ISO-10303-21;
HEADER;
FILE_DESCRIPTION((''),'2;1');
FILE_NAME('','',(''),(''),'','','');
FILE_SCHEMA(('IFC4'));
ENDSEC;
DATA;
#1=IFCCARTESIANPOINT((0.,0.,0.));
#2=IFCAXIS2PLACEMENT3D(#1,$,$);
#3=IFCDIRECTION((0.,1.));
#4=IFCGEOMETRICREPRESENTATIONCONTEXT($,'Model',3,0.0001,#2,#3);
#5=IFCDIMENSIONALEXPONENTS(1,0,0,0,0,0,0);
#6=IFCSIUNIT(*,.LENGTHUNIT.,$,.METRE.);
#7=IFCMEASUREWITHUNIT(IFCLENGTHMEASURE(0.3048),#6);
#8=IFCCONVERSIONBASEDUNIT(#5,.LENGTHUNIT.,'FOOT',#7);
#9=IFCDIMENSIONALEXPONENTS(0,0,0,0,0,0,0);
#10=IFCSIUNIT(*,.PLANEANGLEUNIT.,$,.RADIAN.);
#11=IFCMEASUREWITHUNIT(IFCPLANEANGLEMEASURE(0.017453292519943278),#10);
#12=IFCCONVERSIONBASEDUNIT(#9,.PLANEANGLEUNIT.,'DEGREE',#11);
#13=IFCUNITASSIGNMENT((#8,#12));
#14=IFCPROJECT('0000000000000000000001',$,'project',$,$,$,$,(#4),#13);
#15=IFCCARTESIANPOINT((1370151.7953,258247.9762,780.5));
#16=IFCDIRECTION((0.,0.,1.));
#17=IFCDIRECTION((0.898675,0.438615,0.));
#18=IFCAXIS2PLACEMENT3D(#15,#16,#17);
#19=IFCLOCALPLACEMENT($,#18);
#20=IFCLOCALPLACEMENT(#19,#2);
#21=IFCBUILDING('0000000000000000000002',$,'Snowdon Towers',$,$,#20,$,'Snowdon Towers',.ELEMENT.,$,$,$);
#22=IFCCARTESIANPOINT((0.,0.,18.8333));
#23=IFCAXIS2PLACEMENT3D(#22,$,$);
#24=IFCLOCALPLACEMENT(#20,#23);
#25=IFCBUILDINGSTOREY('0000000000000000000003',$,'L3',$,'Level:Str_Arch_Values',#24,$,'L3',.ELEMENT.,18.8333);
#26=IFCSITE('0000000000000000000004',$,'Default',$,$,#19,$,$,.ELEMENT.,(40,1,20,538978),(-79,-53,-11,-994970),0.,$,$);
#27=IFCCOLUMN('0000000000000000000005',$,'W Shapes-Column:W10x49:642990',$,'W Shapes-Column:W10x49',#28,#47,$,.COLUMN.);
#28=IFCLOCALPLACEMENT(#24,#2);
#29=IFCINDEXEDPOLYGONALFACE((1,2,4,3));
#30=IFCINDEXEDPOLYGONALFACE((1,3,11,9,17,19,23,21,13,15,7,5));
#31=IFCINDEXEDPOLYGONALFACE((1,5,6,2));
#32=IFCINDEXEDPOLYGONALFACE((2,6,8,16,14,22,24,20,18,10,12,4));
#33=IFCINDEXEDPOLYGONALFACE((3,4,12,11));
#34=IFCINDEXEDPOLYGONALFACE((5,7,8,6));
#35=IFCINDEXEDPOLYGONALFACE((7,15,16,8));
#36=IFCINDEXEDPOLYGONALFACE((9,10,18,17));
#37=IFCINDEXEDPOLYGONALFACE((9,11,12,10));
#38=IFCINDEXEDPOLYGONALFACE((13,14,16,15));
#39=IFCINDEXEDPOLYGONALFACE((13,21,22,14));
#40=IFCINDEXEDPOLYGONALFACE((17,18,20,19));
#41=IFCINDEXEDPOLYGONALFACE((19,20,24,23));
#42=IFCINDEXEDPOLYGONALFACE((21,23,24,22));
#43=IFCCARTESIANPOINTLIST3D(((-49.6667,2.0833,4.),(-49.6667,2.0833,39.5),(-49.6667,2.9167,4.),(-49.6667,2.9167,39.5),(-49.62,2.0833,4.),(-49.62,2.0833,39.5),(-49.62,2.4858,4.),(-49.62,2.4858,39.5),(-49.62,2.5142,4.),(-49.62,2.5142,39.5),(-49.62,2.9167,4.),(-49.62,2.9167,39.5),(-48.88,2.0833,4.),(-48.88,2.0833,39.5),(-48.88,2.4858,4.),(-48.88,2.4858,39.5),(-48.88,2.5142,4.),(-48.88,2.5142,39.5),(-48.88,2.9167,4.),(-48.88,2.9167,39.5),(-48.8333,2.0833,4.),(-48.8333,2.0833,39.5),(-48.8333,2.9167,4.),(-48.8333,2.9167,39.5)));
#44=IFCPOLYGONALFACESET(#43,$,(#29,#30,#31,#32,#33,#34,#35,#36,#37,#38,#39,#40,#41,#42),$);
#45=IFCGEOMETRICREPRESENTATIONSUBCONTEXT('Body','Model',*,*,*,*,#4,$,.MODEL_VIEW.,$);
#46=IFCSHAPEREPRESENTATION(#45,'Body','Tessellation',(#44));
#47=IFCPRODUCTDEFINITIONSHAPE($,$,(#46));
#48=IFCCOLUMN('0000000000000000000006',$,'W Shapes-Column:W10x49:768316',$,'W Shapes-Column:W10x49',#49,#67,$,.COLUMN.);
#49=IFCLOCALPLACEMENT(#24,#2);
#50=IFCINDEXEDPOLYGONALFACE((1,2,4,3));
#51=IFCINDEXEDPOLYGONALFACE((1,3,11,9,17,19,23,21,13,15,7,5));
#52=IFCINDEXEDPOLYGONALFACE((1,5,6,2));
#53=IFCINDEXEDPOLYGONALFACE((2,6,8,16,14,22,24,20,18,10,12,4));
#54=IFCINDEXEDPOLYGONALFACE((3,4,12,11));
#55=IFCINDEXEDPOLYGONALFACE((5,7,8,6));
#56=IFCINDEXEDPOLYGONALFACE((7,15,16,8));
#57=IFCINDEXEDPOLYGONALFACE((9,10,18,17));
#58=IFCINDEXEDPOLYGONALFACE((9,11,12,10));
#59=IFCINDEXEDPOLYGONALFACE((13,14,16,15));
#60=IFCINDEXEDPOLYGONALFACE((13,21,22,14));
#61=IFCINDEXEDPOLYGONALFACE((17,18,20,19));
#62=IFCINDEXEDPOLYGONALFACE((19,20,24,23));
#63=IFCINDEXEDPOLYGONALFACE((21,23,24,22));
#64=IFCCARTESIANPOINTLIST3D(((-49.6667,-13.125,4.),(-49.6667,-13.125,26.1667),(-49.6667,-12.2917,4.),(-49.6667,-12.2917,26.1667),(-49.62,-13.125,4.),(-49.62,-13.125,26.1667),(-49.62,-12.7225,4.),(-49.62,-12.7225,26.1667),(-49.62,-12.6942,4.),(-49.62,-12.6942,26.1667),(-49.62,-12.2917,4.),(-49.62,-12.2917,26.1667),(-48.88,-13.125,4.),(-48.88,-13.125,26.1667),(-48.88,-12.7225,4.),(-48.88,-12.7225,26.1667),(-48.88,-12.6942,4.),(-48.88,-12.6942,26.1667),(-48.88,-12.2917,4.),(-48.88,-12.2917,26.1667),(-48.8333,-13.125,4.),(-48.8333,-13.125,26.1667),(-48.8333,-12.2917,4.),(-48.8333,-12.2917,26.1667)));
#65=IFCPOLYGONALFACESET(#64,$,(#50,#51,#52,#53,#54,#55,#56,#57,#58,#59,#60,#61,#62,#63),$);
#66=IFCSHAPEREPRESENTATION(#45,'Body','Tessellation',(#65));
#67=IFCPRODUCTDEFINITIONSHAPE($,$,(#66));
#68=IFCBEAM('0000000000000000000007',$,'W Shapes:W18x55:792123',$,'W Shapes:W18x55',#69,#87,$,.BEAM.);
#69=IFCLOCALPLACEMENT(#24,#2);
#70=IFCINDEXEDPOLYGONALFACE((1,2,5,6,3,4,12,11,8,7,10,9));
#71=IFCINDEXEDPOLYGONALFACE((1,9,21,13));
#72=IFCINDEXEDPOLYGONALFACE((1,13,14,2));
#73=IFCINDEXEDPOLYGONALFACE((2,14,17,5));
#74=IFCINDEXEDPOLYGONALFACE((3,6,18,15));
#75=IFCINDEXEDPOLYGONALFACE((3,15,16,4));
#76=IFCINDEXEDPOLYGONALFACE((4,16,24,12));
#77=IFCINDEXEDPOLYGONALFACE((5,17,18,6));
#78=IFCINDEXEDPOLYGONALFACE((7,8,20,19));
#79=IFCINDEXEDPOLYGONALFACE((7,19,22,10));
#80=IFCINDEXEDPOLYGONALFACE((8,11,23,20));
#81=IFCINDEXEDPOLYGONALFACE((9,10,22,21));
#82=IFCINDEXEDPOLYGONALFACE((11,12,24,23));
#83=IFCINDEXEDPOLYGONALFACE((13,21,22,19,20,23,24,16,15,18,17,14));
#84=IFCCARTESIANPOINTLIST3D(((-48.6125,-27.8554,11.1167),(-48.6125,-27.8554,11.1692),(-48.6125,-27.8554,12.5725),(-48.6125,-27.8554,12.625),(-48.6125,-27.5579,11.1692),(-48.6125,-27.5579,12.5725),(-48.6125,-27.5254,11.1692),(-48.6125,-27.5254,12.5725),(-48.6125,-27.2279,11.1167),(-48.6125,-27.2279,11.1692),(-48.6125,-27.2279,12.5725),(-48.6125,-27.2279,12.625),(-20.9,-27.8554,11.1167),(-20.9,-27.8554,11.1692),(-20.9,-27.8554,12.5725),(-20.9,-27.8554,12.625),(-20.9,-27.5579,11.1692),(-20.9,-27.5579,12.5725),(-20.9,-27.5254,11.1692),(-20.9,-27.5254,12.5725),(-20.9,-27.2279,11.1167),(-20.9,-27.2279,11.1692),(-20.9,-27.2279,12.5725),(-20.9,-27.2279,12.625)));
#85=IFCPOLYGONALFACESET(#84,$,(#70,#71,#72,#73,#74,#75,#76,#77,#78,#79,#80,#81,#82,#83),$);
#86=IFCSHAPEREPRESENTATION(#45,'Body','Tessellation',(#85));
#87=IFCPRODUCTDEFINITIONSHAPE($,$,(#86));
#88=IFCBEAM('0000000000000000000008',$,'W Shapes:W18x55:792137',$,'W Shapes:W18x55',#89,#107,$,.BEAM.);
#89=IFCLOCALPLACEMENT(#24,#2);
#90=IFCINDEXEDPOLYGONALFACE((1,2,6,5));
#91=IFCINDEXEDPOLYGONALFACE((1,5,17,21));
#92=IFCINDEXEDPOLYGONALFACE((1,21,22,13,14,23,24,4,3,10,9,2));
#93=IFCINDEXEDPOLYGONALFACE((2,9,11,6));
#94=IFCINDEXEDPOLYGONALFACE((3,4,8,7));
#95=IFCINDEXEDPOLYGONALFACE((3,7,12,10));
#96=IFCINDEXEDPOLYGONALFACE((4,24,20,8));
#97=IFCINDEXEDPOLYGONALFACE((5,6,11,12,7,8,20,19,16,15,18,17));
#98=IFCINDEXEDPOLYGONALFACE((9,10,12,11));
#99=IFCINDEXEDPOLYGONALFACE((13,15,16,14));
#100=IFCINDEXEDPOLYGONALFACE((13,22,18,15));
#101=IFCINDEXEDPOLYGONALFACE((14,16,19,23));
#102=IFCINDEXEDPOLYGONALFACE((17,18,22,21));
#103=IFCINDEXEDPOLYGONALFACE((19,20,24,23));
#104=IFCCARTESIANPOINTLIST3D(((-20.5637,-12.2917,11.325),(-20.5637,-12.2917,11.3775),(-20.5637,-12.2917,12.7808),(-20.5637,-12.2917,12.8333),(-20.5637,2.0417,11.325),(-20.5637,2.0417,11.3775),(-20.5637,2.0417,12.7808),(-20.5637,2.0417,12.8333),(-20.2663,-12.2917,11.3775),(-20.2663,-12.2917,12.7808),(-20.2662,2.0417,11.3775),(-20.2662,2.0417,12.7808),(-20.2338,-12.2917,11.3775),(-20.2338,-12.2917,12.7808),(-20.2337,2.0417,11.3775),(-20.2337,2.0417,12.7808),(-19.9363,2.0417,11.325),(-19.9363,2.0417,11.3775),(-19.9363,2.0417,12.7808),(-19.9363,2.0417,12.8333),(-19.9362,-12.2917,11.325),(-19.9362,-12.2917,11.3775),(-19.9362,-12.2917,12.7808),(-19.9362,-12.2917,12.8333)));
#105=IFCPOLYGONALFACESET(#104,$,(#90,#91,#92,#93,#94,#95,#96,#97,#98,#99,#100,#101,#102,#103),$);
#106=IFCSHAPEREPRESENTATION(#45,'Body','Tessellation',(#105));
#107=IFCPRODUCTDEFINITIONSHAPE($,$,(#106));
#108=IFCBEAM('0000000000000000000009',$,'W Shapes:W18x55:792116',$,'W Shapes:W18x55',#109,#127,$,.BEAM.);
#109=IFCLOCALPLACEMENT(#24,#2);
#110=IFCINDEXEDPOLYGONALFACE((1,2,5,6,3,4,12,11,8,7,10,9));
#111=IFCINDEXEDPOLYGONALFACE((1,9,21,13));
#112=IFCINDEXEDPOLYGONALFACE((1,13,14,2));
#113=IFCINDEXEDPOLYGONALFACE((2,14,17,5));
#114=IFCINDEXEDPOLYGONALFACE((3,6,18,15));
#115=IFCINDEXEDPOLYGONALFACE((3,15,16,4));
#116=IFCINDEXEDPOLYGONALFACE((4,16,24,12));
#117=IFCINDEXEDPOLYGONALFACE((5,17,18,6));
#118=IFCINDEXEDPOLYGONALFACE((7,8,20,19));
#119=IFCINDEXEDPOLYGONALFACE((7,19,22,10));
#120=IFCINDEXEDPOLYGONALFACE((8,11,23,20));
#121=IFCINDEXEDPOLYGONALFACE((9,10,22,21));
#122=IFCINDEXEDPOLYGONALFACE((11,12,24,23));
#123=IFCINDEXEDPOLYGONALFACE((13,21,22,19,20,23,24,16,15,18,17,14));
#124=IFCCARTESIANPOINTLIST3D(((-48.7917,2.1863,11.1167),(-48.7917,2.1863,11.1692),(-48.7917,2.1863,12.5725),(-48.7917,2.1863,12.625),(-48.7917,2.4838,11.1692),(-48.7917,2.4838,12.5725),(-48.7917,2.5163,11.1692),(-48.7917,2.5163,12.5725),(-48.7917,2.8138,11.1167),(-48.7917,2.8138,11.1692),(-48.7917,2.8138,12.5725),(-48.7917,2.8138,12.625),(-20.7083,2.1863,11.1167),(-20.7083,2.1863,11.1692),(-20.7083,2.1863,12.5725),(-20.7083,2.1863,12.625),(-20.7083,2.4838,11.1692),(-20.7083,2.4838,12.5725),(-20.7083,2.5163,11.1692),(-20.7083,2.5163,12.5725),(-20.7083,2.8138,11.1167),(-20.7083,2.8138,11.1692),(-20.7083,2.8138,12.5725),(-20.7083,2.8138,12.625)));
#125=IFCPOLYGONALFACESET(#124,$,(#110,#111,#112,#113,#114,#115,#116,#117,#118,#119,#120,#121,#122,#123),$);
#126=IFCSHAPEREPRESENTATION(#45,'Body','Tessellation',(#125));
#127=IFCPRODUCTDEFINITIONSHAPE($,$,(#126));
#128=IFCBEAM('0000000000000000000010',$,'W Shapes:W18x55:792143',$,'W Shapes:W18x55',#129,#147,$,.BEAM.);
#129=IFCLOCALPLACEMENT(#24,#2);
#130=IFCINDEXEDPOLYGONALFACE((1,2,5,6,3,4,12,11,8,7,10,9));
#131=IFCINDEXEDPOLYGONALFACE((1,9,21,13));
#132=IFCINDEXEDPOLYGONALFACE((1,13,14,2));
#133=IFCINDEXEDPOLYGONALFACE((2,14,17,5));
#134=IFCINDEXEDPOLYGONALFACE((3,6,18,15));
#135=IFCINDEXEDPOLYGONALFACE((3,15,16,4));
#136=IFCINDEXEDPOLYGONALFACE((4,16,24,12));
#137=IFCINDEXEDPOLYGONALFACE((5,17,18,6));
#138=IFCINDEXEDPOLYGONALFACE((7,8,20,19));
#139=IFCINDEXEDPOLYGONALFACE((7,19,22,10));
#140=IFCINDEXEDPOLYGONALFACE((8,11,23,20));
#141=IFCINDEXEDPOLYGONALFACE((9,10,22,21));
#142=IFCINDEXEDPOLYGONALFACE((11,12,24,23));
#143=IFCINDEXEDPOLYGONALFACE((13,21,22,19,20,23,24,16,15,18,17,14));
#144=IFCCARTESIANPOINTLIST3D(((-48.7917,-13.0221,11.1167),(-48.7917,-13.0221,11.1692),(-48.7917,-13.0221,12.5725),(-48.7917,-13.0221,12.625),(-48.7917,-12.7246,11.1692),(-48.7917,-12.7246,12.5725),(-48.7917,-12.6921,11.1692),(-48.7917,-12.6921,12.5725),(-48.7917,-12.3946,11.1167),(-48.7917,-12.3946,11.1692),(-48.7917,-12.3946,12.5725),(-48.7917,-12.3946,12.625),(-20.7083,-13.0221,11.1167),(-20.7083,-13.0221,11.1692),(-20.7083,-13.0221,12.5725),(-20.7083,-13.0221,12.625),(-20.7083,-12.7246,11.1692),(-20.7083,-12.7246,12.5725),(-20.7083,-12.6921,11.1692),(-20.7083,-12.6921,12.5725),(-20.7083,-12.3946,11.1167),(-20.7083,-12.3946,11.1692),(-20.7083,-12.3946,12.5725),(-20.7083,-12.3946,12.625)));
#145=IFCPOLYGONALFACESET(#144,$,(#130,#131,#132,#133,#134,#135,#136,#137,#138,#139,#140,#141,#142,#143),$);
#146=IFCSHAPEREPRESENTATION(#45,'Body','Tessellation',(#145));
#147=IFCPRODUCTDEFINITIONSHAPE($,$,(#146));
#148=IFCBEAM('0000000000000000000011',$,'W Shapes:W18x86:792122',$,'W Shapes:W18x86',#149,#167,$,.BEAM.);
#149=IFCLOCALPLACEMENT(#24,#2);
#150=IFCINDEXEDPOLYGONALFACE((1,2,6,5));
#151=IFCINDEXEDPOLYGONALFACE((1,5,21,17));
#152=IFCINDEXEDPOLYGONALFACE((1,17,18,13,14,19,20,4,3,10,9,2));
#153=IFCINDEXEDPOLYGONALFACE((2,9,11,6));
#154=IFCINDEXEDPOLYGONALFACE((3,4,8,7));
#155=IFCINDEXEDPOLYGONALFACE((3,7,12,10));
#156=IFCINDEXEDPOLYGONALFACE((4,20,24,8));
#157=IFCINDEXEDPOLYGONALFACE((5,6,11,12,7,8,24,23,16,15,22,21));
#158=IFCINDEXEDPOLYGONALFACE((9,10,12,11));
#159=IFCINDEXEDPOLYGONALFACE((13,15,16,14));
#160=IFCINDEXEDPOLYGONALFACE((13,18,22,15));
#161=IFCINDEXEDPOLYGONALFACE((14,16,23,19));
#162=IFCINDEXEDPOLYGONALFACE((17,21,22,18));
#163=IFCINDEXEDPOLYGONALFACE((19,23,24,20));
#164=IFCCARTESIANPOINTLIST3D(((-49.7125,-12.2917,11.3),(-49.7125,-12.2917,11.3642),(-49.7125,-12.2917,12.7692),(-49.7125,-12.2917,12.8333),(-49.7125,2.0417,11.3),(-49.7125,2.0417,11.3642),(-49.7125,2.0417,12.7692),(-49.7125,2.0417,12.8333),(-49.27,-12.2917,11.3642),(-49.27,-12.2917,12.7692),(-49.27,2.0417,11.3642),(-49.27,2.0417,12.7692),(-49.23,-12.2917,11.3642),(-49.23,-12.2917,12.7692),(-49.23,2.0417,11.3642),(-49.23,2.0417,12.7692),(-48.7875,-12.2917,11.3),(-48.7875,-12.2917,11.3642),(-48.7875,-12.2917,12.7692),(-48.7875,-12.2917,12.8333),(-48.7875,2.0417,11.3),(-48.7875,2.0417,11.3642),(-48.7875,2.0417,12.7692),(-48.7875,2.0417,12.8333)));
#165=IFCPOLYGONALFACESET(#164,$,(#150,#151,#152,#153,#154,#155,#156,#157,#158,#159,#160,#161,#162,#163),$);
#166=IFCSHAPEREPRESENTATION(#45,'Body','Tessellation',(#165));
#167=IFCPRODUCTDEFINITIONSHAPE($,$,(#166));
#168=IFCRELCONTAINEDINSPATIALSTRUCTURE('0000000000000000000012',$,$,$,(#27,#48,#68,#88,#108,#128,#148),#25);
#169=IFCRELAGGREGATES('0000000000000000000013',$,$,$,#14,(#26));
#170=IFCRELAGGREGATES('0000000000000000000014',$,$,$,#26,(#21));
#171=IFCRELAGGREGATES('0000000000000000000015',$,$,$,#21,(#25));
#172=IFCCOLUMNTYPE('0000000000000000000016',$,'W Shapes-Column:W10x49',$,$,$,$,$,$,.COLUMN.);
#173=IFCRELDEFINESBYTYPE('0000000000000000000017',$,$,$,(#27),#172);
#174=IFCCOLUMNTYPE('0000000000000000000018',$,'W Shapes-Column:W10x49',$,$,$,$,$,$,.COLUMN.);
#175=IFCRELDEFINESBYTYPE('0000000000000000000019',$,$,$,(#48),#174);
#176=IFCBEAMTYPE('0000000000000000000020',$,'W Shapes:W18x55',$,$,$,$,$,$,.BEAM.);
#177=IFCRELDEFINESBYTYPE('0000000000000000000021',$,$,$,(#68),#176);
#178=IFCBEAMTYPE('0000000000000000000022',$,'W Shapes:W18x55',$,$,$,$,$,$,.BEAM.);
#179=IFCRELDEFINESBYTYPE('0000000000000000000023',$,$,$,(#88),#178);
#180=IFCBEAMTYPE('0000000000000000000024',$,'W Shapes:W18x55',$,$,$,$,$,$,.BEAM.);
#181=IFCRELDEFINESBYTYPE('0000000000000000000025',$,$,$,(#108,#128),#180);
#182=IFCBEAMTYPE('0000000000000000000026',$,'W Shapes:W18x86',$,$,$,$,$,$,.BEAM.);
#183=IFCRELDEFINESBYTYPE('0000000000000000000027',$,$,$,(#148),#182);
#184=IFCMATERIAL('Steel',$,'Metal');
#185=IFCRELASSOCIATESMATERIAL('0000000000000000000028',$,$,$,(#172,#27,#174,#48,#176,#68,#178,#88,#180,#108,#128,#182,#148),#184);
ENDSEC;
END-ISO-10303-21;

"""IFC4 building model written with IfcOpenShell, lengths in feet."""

from ifc_helpers import new_model, entity, si_unit, converted_unit, direction, frame, origin, place, context, subcontext, project, spatial, indexed_curve, outline, extrude, source, transform, mapped, material, type_object, type_shapes, element, save


model = new_model("IFC4")

# Units and contexts
model_context = context("Model", 3, precision=0.0001, world=origin(), true_north=direction((0.0, 1.0)))
body_context = subcontext(model_context, "Body", "Model", "MODEL_VIEW")
ifc_project = project(units=[converted_unit("LENGTHUNIT", "FOOT", entity("IfcLengthMeasure", 0.3048), si_unit("LENGTHUNIT", "METRE"), dimensions=[1, 0, 0, 0, 0, 0, 0]), converted_unit("PLANEANGLEUNIT", "DEGREE", entity("IfcPlaneAngleMeasure", 0.017453292519943278), si_unit("PLANEANGLEUNIT", "RADIAN"), dimensions=[0, 0, 0, 0, 0, 0, 0])], contexts=[model_context])

# Site, building, storey
site_placement = place(None, frame((1370151.7953, 258247.9762, 780.5), z_axis=(0.0, 0.0, 1.0), x_axis=(0.898675, 0.438615, 0.0)))
site = spatial("IfcSite", under=ifc_project, at=site_placement, Name="Default", CompositionType="ELEMENT", RefLatitude=(40, 1, 20, 538978), RefLongitude=(-79, -53, -11, -994970), RefElevation=0.0)
building_placement = place(site_placement, origin())
building = spatial("IfcBuilding", under=site, at=building_placement, Name="Snowdon Towers", LongName="Snowdon Towers", CompositionType="ELEMENT")
storey_placement = place(building_placement, frame((0.0, 0.0, 18.8333)))
storey = spatial("IfcBuildingStorey", under=building, at=storey_placement, Name="L3", ObjectType="Level:Str_Arch_Values", LongName="L3", CompositionType="ELEMENT", Elevation=18.8333)

# Columns
ifc_material = material(Name="Steel", Category="Metal")
column_type_1 = type_object("IfcColumnType", Name="W Shapes-Column:W10x49", PredefinedType="COLUMN", material=ifc_material)
shared_shape_1 = source(origin(), body_context, "Body", "SweptSolid", [
    extrude(outline(indexed_curve([(-0.4167, -0.4167), (0.4167, -0.4167), (0.4167, -0.37), (0.0142, -0.37), (0.0142, 0.37), (0.4167, 0.37), (0.4167, 0.4167), (-0.4167, 0.4167), (-0.4167, 0.37), (-0.0142, 0.37), (-0.0142, -0.37), (-0.4167, -0.37), (-0.4167, -0.4167)], self_intersect=False)), frame((0.0, 0.0, 22.8333), z_axis=(0.0, 0.0, 1.0), x_axis=(-1.0, 0.0, 0.0)), (0.0, 0.0, 1.0), 35.5),
])
type_shapes(column_type_1, [shared_shape_1])
column_1_placement = place(storey_placement, frame((-49.25, 2.5, -18.8333), z_axis=(0.0, 0.0, 1.0), x_axis=(0.0, 1.0, 0.0)))
element("IfcColumn", 1, at=column_1_placement, inside=storey, type_object=column_type_1, material=ifc_material, Name="W Shapes-Column:W10x49:642990", ObjectType="W Shapes-Column:W10x49", PredefinedType="COLUMN", context=body_context, shape_type="MappedRepresentation", body=[
    mapped(shared_shape_1, transform((0.0, 0.0, 0.0), scale=1.0)),
])
column_type_2 = type_object("IfcColumnType", Name="W Shapes-Column:W10x49", PredefinedType="COLUMN", material=ifc_material)
shared_shape_2 = source(origin(), body_context, "Body", "SweptSolid", [
    extrude(outline(indexed_curve([(-0.4167, -0.4167), (0.4167, -0.4167), (0.4167, -0.37), (0.0142, -0.37), (0.0142, 0.37), (0.4167, 0.37), (0.4167, 0.4167), (-0.4167, 0.4167), (-0.4167, 0.37), (-0.0142, 0.37), (-0.0142, -0.37), (-0.4167, -0.37), (-0.4167, -0.4167)], self_intersect=False)), frame((0.0, 0.0, 22.8333), z_axis=(0.0, 0.0, 1.0), x_axis=(-1.0, 0.0, 0.0)), (0.0, 0.0, 1.0), 22.1667),
])
type_shapes(column_type_2, [shared_shape_2])
column_2_placement = place(storey_placement, frame((-49.25, -12.7083, -18.8333), z_axis=(0.0, 0.0, 1.0), x_axis=(0.0, 1.0, 0.0)))
element("IfcColumn", 2, at=column_2_placement, inside=storey, type_object=column_type_2, material=ifc_material, Name="W Shapes-Column:W10x49:768316", ObjectType="W Shapes-Column:W10x49", PredefinedType="COLUMN", context=body_context, shape_type="MappedRepresentation", body=[
    mapped(shared_shape_2, transform((0.0, 0.0, 0.0), scale=1.0)),
])

# Beams
beam_type_1 = type_object("IfcBeamType", Name="W Shapes:W18x55", PredefinedType="BEAM", material=ifc_material)
shared_shape_3 = source(origin(), body_context, "Body", "SweptSolid", [
    extrude(outline(indexed_curve([(-0.3138, -0.7017), (-0.3138, -0.7542), (0.3138, -0.7542), (0.3138, -0.7017), (0.0162, -0.7017), (0.0162, 0.7017), (0.3138, 0.7017), (0.3138, 0.7542), (-0.3137, 0.7542), (-0.3137, 0.7017), (-0.0163, 0.7017), (-0.0163, -0.7017), (-0.3138, -0.7017)], self_intersect=False)), frame((-13.8625, 0.0, 0.0), z_axis=(-1.0, 0.0, 0.0), x_axis=(0.0, -1.0, 0.0)), (0.0, 0.0, -1.0), 27.7125),
])
type_shapes(beam_type_1, [shared_shape_3])
beam_1_placement = place(storey_placement, frame((-34.75, -27.5417, 11.8708)))
element("IfcBeam", 3, at=beam_1_placement, inside=storey, type_object=beam_type_1, material=ifc_material, Name="W Shapes:W18x55:792123", ObjectType="W Shapes:W18x55", PredefinedType="BEAM", context=body_context, shape_type="MappedRepresentation", body=[
    mapped(shared_shape_3, transform((0.0, 0.0, 0.0), scale=1.0)),
])
beam_type_2 = type_object("IfcBeamType", Name="W Shapes:W18x55", PredefinedType="BEAM", material=ifc_material)
shared_shape_4 = source(origin(), body_context, "Body", "SweptSolid", [
    extrude(outline(indexed_curve([(-0.3138, -0.7017), (-0.3138, -0.7542), (0.3138, -0.7542), (0.3138, -0.7017), (0.0162, -0.7017), (0.0162, 0.7017), (0.3138, 0.7017), (0.3138, 0.7542), (-0.3137, 0.7542), (-0.3137, 0.7017), (-0.0163, 0.7017), (-0.0163, -0.7017), (-0.3138, -0.7017)], self_intersect=False)), frame((-7.1458, 0.0, 0.0), z_axis=(-1.0, 0.0, 0.0), x_axis=(0.0, -1.0, 0.0)), (0.0, 0.0, -1.0), 14.3333),
])
type_shapes(beam_type_2, [shared_shape_4])
beam_2_placement = place(storey_placement, frame((-20.25, -5.1042, 12.0792), z_axis=(0.0, 0.0, 1.0), x_axis=(0.0, -1.0, 0.0)))
element("IfcBeam", 4, at=beam_2_placement, inside=storey, type_object=beam_type_2, material=ifc_material, Name="W Shapes:W18x55:792137", ObjectType="W Shapes:W18x55", PredefinedType="BEAM", context=body_context, shape_type="MappedRepresentation", body=[
    mapped(shared_shape_4, transform((0.0, 0.0, 0.0), scale=1.0)),
])

# Beams
beam_type_3 = type_object("IfcBeamType", Name="W Shapes:W18x55", PredefinedType="BEAM", material=ifc_material)
shared_shape_5 = source(origin(), body_context, "Body", "SweptSolid", [
    extrude(outline(indexed_curve([(-0.3138, -0.7017), (-0.3138, -0.7542), (0.3138, -0.7542), (0.3138, -0.7017), (0.0162, -0.7017), (0.0162, 0.7017), (0.3138, 0.7017), (0.3138, 0.7542), (-0.3137, 0.7542), (-0.3137, 0.7017), (-0.0163, 0.7017), (-0.0163, -0.7017), (-0.3138, -0.7017)], self_intersect=False)), frame((-14.0417, 0.0, 0.0), z_axis=(-1.0, 0.0, 0.0), x_axis=(0.0, -1.0, 0.0)), (0.0, 0.0, -1.0), 28.0833),
])
type_shapes(beam_type_3, [shared_shape_5])
for number, where, name in (
    (5, (-34.75, 2.5, 11.8708), "W Shapes:W18x55:792116"),
    (6, (-34.75, -12.7083, 11.8708), "W Shapes:W18x55:792143"),
):
    element("IfcBeam", number, at=place(storey_placement, frame(where)), inside=storey, type_object=beam_type_3, material=ifc_material, Name=name, ObjectType="W Shapes:W18x55", PredefinedType="BEAM", context=body_context, shape_type="MappedRepresentation", body=[
        mapped(shared_shape_5, transform((0.0, 0.0, 0.0), scale=1.0)),
    ])
beam_type_4 = type_object("IfcBeamType", Name="W Shapes:W18x86", PredefinedType="BEAM", material=ifc_material)
shared_shape_6 = source(origin(), body_context, "Body", "SweptSolid", [
    extrude(outline(indexed_curve([(-0.4625, -0.7025), (-0.4625, -0.7667), (0.4625, -0.7667), (0.4625, -0.7025), (0.02, -0.7025), (0.02, 0.7025), (0.4625, 0.7025), (0.4625, 0.7667), (-0.4625, 0.7667), (-0.4625, 0.7025), (-0.02, 0.7025), (-0.02, -0.7025), (-0.4625, -0.7025)], self_intersect=False)), frame((-7.1458, 0.0, 0.0), z_axis=(-1.0, 0.0, 0.0), x_axis=(0.0, -1.0, 0.0)), (0.0, 0.0, -1.0), 14.3333),
])
type_shapes(beam_type_4, [shared_shape_6])
beam_3_placement = place(storey_placement, frame((-49.25, -5.1042, 12.0667), z_axis=(0.0, 0.0, 1.0), x_axis=(0.0, -1.0, 0.0)))
element("IfcBeam", 7, at=beam_3_placement, inside=storey, type_object=beam_type_4, material=ifc_material, Name="W Shapes:W18x86:792122", ObjectType="W Shapes:W18x86", PredefinedType="BEAM", context=body_context, shape_type="MappedRepresentation", body=[
    mapped(shared_shape_6, transform((0.0, 0.0, 0.0), scale=1.0)),
])

save(model, "model.ifc")
